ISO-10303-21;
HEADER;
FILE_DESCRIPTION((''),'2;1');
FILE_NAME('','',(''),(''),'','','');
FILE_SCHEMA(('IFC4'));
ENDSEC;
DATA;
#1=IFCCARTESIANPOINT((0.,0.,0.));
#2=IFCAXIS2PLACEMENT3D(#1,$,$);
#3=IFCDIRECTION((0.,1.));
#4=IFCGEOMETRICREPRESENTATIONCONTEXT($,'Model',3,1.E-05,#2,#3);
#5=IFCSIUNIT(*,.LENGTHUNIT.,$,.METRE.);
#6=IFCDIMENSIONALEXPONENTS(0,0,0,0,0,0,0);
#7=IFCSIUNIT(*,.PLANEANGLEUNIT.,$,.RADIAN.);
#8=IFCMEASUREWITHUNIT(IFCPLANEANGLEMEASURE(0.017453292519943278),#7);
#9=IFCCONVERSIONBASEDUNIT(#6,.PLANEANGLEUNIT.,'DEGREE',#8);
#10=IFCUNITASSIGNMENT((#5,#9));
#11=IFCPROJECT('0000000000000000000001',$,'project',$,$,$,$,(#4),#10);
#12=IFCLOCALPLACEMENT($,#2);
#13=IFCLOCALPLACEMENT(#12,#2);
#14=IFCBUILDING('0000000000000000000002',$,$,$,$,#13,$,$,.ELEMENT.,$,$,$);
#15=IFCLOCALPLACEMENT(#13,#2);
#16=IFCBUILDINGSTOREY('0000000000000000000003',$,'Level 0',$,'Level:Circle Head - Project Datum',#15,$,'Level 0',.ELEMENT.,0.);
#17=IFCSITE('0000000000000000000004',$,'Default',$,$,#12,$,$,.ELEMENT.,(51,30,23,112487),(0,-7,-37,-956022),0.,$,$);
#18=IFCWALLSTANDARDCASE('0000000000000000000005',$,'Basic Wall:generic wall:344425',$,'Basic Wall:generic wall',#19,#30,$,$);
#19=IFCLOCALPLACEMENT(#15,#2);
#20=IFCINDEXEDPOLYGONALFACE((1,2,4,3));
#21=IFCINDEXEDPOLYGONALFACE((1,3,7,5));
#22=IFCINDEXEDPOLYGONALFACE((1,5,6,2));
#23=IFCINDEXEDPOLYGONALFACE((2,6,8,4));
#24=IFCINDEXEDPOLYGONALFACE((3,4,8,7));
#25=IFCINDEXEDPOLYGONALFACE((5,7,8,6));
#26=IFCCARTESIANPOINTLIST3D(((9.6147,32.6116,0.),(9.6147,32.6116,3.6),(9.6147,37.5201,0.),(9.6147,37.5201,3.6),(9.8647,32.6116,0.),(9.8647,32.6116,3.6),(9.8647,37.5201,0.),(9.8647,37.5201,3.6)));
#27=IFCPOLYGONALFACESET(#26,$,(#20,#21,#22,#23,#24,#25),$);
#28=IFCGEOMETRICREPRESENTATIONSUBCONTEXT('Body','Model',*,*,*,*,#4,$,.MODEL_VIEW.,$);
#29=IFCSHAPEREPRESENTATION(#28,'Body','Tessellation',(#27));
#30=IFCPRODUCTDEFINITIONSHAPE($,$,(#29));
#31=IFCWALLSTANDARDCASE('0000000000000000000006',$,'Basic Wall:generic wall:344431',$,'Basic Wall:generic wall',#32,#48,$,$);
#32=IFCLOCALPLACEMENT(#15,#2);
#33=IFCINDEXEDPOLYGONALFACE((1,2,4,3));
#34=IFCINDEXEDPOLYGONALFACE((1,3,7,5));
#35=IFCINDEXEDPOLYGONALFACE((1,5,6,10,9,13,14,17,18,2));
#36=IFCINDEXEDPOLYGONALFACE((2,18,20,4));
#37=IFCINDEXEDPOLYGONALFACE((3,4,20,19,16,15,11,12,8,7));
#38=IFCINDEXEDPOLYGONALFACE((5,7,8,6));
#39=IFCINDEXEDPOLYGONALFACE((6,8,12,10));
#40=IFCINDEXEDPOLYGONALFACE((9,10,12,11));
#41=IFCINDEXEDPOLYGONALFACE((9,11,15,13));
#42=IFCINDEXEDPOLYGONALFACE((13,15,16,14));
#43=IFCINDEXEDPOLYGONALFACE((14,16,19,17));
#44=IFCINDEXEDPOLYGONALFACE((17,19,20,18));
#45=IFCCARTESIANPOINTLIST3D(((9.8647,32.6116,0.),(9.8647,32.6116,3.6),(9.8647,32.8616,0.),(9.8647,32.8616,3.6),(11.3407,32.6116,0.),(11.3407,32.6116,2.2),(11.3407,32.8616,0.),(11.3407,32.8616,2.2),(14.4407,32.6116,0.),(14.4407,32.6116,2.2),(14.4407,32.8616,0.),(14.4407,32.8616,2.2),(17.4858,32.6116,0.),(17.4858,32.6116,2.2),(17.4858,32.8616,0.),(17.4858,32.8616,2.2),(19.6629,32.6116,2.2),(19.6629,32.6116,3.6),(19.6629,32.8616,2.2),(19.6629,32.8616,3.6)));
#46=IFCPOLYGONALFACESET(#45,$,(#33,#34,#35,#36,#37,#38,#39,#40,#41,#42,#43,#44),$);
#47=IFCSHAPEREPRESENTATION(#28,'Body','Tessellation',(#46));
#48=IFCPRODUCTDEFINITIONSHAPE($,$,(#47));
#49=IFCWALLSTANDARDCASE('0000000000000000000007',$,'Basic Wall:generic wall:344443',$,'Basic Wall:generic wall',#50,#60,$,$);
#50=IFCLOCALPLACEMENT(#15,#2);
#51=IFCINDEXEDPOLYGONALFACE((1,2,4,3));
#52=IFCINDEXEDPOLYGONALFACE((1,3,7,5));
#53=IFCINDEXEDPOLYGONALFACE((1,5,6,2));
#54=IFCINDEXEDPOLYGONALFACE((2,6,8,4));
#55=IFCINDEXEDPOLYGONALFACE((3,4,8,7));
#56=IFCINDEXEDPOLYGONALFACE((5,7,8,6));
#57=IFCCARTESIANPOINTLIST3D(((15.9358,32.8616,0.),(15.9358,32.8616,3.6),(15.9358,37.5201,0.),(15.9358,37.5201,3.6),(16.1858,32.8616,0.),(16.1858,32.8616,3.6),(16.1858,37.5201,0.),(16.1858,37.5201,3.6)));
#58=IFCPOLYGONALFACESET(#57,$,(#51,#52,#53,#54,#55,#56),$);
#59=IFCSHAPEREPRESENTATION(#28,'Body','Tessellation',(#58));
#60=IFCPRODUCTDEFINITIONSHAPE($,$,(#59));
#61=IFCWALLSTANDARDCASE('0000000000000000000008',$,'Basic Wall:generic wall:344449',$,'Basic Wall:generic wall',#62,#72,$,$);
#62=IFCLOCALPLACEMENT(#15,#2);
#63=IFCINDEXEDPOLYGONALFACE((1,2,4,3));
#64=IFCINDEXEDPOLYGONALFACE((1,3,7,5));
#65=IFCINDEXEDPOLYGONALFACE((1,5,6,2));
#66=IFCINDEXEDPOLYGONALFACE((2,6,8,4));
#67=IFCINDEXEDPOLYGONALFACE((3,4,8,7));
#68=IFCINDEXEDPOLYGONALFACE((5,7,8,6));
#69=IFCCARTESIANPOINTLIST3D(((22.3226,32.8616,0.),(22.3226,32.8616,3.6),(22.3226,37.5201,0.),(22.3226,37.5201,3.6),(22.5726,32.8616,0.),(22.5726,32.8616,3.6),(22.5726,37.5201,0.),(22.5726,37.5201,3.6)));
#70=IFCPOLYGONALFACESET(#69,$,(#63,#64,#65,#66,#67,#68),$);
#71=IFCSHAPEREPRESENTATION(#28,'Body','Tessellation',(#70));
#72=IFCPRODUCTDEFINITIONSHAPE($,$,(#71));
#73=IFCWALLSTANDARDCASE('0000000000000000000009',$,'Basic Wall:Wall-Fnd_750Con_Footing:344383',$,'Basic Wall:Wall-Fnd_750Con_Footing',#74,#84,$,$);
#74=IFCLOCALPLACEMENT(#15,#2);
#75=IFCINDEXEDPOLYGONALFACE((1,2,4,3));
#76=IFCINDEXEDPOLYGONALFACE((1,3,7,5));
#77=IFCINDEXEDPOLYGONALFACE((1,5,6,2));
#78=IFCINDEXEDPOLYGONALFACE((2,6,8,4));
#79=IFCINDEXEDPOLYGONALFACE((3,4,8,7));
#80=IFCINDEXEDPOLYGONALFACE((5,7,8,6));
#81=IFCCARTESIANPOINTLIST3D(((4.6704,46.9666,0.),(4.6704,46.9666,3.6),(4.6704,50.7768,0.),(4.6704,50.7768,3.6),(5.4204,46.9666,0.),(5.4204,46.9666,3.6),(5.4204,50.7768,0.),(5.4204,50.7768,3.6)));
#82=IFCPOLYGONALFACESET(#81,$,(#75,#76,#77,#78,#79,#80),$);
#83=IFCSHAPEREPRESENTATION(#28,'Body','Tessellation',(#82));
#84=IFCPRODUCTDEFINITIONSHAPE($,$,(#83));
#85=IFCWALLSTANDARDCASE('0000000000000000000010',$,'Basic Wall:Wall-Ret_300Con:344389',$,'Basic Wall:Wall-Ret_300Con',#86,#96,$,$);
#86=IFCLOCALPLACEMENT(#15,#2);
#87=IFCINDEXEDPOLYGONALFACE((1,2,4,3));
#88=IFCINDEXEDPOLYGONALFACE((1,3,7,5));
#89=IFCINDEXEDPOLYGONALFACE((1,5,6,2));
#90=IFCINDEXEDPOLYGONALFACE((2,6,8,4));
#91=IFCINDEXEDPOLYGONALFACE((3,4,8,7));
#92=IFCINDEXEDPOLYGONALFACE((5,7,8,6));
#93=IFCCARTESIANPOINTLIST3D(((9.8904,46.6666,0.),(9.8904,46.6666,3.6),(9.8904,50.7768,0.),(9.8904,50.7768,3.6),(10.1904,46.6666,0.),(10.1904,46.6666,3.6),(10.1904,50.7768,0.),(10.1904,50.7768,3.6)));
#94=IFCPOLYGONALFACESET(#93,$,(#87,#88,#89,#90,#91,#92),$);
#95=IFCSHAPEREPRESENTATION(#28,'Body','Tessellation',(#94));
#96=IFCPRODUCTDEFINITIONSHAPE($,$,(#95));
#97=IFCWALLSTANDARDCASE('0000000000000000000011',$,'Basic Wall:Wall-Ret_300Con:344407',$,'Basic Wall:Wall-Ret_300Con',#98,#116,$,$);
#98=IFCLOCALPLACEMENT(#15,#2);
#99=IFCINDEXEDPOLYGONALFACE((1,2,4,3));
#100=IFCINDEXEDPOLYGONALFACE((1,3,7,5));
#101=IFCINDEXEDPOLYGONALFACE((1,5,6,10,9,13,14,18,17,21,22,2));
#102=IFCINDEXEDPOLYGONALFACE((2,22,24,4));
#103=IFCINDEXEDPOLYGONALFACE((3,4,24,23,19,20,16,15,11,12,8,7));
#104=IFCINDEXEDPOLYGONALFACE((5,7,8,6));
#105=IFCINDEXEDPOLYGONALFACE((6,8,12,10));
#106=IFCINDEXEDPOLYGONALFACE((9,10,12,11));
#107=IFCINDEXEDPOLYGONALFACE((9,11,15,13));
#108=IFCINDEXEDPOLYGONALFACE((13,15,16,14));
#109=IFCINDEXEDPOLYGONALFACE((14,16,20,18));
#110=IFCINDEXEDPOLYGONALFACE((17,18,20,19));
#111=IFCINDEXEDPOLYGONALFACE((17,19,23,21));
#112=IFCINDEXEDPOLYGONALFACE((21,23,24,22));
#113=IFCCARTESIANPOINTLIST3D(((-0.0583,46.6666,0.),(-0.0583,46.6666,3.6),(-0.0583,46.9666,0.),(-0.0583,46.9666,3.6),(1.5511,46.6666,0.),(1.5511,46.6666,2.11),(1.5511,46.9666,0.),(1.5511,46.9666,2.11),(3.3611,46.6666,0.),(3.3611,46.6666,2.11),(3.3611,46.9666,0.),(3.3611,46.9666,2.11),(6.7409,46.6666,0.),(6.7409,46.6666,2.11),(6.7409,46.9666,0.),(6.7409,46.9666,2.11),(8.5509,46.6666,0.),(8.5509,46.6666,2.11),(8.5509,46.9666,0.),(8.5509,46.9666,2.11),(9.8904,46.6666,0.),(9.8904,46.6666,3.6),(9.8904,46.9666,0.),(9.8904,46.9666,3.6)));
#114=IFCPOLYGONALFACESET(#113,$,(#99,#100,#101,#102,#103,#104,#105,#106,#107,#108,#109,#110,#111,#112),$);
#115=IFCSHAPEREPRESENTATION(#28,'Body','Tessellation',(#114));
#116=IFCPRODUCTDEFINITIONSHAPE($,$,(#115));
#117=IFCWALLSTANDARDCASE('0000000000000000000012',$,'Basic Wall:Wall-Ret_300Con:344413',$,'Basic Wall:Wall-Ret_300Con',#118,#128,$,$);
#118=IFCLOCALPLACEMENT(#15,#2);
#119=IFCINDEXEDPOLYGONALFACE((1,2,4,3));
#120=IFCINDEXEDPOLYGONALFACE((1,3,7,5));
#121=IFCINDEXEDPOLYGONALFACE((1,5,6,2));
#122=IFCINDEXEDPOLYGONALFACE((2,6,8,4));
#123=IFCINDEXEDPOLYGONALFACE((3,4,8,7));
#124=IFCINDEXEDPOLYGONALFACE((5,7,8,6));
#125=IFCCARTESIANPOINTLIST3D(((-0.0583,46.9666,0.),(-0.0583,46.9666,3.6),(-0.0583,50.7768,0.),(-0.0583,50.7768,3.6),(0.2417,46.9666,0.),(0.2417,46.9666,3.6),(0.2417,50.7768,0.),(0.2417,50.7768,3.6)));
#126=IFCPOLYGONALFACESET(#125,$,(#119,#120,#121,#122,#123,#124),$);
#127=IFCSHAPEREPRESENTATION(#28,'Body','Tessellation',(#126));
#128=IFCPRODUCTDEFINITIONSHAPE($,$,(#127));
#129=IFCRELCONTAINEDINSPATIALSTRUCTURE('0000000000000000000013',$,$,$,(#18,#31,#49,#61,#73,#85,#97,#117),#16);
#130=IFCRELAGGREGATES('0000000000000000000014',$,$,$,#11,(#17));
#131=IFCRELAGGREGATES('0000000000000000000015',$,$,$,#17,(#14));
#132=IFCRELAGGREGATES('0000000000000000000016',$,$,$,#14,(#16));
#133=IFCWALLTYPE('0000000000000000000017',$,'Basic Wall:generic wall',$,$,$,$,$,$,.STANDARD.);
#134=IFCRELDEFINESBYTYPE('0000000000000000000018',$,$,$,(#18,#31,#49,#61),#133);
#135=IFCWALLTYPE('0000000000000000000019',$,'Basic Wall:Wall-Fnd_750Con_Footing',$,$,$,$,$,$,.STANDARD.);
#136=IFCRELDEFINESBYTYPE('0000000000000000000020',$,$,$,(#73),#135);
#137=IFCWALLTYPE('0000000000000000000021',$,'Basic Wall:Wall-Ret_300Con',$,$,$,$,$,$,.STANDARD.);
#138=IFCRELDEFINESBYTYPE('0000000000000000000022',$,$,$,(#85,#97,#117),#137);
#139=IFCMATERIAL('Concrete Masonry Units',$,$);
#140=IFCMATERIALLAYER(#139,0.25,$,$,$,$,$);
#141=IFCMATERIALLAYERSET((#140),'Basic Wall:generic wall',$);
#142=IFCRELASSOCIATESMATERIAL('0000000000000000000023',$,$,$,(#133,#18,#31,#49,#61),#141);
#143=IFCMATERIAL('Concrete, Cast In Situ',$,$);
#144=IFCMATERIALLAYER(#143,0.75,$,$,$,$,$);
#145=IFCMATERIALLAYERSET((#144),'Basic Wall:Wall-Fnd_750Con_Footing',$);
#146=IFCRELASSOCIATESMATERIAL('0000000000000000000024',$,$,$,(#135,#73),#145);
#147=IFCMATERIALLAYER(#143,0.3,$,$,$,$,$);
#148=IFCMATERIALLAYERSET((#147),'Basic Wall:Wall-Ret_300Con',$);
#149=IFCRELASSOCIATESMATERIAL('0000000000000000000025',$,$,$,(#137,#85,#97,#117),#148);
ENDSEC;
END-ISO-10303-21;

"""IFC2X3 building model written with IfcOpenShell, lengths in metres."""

from ifc_helpers import new_model, entity, si_unit, converted_unit, direction, frame, frame_2d, origin, place, context, subcontext, project, spatial, rectangle, extrude, material, layer, layer_set, layer_usage, type_object, element, save


model = new_model("IFC2X3")

# Units and contexts
model_context = context("Model", 3, precision=1e-05, world=origin(), true_north=direction((0.0, 1.0)))
body_context = subcontext(model_context, "Body", "Model", "MODEL_VIEW")
ifc_project = project(units=[si_unit("LENGTHUNIT", "METRE"), converted_unit("PLANEANGLEUNIT", "DEGREE", entity("IfcPlaneAngleMeasure", 0.017453292519943278), si_unit("PLANEANGLEUNIT", "RADIAN"), dimensions=[0, 0, 0, 0, 0, 0, 0])], contexts=[model_context])

# Site, building, storey
site_placement = place(None, origin())
site = spatial("IfcSite", under=ifc_project, at=site_placement, Name="Default", CompositionType="ELEMENT", RefLatitude=(51, 30, 23, 112487), RefLongitude=(0, -7, -37, -956022), RefElevation=0.0)
building_placement = place(site_placement, origin())
building = spatial("IfcBuilding", under=site, at=building_placement, CompositionType="ELEMENT")
storey_placement = place(building_placement, origin())
storey = spatial("IfcBuildingStorey", under=building, at=storey_placement, Name="Level 0", ObjectType="Level:Circle Head - Project Datum", LongName="Level 0", CompositionType="ELEMENT", Elevation=0.0)

# Shared definitions
ifc_material_1 = material(Name="Concrete Masonry Units")
ifc_layer_1 = layer(ifc_material_1, 0.25)
ifc_layer_set_1 = layer_set([ifc_layer_1], Name="Basic Wall:generic wall")
wall_type_1 = type_object("IfcWallType", Name="Basic Wall:generic wall", PredefinedType="STANDARD", material=ifc_layer_set_1)

# Wall
ifc_layer_usage_1 = layer_usage(ifc_layer_set_1, "AXIS2", "NEGATIVE", 0.125)
wall_1_placement = place(storey_placement, frame((9.7397, 32.6116, 0.0), z_axis=(0.0, 0.0, 1.0), x_axis=(0.0, 1.0, 0.0)))
element("IfcWallStandardCase", 1, at=wall_1_placement, inside=storey, type_object=wall_type_1, material=ifc_layer_usage_1, Name="Basic Wall:generic wall:344425", ObjectType="Basic Wall:generic wall", context=body_context, shape_type="SweptSolid", body=[
    extrude(rectangle(XDim=4.9086, YDim=0.25, at=frame_2d((2.4543, 0.0), x_axis=(-1.0, 0.0))), origin(), (0.0, 0.0, 1.0), 3.6),
])

# Wall, openings
ifc_layer_usage_2 = layer_usage(ifc_layer_set_1, "AXIS2", "NEGATIVE", 0.125)
wall_2_placement = place(storey_placement, frame((19.6629, 32.7366, 0.0), z_axis=(0.0, 0.0, 1.0), x_axis=(-1.0, 0.0, 0.0)))
wall_2 = element("IfcWallStandardCase", 2, at=wall_2_placement, inside=storey, type_object=wall_type_1, material=ifc_layer_usage_2, Name="Basic Wall:generic wall:344431", ObjectType="Basic Wall:generic wall", context=body_context, shape_type="SweptSolid", body=[
    extrude(rectangle(XDim=9.7982, YDim=0.25, at=frame_2d((4.8991, 0.0), x_axis=(-1.0, 0.0))), origin(), (0.0, 0.0, 1.0), 3.6),
])
opening_1_placement = place(wall_2_placement, frame((2.1771, 0.125, 0.0)))
element("IfcOpeningElement", 3, at=opening_1_placement, cuts=wall_2, ObjectType="Opening", context=body_context, shape_type="SweptSolid", body=[
    extrude(rectangle(XDim=2.2, YDim=3.1, at=frame_2d((1.1, 1.55), x_axis=(1.0, 0.0))), frame((0.0, 0.0, 0.0), z_axis=(0.0, -1.0, 0.0), x_axis=(0.0, 0.0, 1.0)), (0.0, 0.0, 1.0), 0.25),
])
opening_2_placement = place(wall_2_placement, frame((8.3222, 0.125, 0.0)))
element("IfcOpeningElement", 4, at=opening_2_placement, cuts=wall_2, ObjectType="Opening", context=body_context, shape_type="SweptSolid", body=[
    extrude(rectangle(XDim=2.2, YDim=3.1, at=frame_2d((1.1, 1.55), x_axis=(1.0, 0.0))), frame((0.0, 0.0, 0.0), z_axis=(0.0, -1.0, 0.0), x_axis=(0.0, 0.0, 1.0)), (0.0, 0.0, 1.0), 0.25),
])

# Walls
ifc_layer_usage_3 = layer_usage(ifc_layer_set_1, "AXIS2", "NEGATIVE", 0.125)
wall_3_placement = place(storey_placement, frame((16.0608, 37.5201, 0.0), z_axis=(0.0, 0.0, 1.0), x_axis=(0.0, -1.0, 0.0)))
element("IfcWallStandardCase", 5, at=wall_3_placement, inside=storey, type_object=wall_type_1, material=ifc_layer_usage_3, Name="Basic Wall:generic wall:344443", ObjectType="Basic Wall:generic wall", context=body_context, shape_type="SweptSolid", body=[
    extrude(rectangle(XDim=4.6586, YDim=0.25, at=frame_2d((2.3293, 0.0), x_axis=(-1.0, 0.0))), origin(), (0.0, 0.0, 1.0), 3.6),
])
ifc_layer_usage_4 = layer_usage(ifc_layer_set_1, "AXIS2", "NEGATIVE", 0.125)
wall_4_placement = place(storey_placement, frame((22.4476, 37.5201, 0.0), z_axis=(0.0, 0.0, 1.0), x_axis=(0.0, -1.0, 0.0)))
element("IfcWallStandardCase", 6, at=wall_4_placement, inside=storey, type_object=wall_type_1, material=ifc_layer_usage_4, Name="Basic Wall:generic wall:344449", ObjectType="Basic Wall:generic wall", context=body_context, shape_type="SweptSolid", body=[
    extrude(rectangle(XDim=4.6586, YDim=0.25, at=frame_2d((2.3293, 0.0), x_axis=(-1.0, 0.0))), origin(), (0.0, 0.0, 1.0), 3.6),
])
ifc_material_2 = material(Name="Concrete, Cast In Situ")
ifc_layer_2 = layer(ifc_material_2, 0.75)
ifc_layer_set_2 = layer_set([ifc_layer_2], Name="Basic Wall:Wall-Fnd_750Con_Footing")
ifc_layer_usage_5 = layer_usage(ifc_layer_set_2, "AXIS2", "NEGATIVE", 0.375)
wall_type_2 = type_object("IfcWallType", Name="Basic Wall:Wall-Fnd_750Con_Footing", PredefinedType="STANDARD", material=ifc_layer_set_2)
wall_5_placement = place(storey_placement, frame((5.0454, 50.7768, 0.0), z_axis=(0.0, 0.0, 1.0), x_axis=(0.0, -1.0, 0.0)))
element("IfcWallStandardCase", 7, at=wall_5_placement, inside=storey, type_object=wall_type_2, material=ifc_layer_usage_5, Name="Basic Wall:Wall-Fnd_750Con_Footing:344383", ObjectType="Basic Wall:Wall-Fnd_750Con_Footing", context=body_context, shape_type="SweptSolid", body=[
    extrude(rectangle(XDim=3.8102, YDim=0.75, at=frame_2d((1.9051, 0.0), x_axis=(-1.0, 0.0))), origin(), (0.0, 0.0, 1.0), 3.6),
])
ifc_layer_3 = layer(ifc_material_2, 0.3)
ifc_layer_set_3 = layer_set([ifc_layer_3], Name="Basic Wall:Wall-Ret_300Con")
ifc_layer_usage_6 = layer_usage(ifc_layer_set_3, "AXIS2", "NEGATIVE", 0.15)
wall_type_3 = type_object("IfcWallType", Name="Basic Wall:Wall-Ret_300Con", PredefinedType="STANDARD", material=ifc_layer_set_3)
wall_6_placement = place(storey_placement, frame((10.0404, 46.6666, 0.0), z_axis=(0.0, 0.0, 1.0), x_axis=(0.0, 1.0, 0.0)))
element("IfcWallStandardCase", 8, at=wall_6_placement, inside=storey, type_object=wall_type_3, material=ifc_layer_usage_6, Name="Basic Wall:Wall-Ret_300Con:344389", ObjectType="Basic Wall:Wall-Ret_300Con", context=body_context, shape_type="SweptSolid", body=[
    extrude(rectangle(XDim=4.1102, YDim=0.3, at=frame_2d((2.0551, 0.0), x_axis=(-1.0, 0.0))), origin(), (0.0, 0.0, 1.0), 3.6),
])

# Wall, openings
ifc_layer_usage_7 = layer_usage(ifc_layer_set_3, "AXIS2", "NEGATIVE", 0.15)
wall_7_placement = place(storey_placement, frame((9.8904, 46.8166, 0.0), z_axis=(0.0, 0.0, 1.0), x_axis=(-1.0, 0.0, 0.0)))
wall_7 = element("IfcWallStandardCase", 9, at=wall_7_placement, inside=storey, type_object=wall_type_3, material=ifc_layer_usage_7, Name="Basic Wall:Wall-Ret_300Con:344407", ObjectType="Basic Wall:Wall-Ret_300Con", context=body_context, shape_type="SweptSolid", body=[
    extrude(rectangle(XDim=9.9487, YDim=0.3, at=frame_2d((4.9744, 0.0), x_axis=(1.0, 0.0))), origin(), (0.0, 0.0, 1.0), 3.6),
])
opening_3_placement = place(wall_7_placement, frame((3.1495, 0.15, 0.0)))
element("IfcOpeningElement", 10, at=opening_3_placement, cuts=wall_7, ObjectType="Opening", context=body_context, shape_type="SweptSolid", body=[
    extrude(rectangle(XDim=2.11, YDim=1.81, at=frame_2d((1.055, 0.905), x_axis=(-1.0, 0.0))), frame((0.0, 0.0, 0.0), z_axis=(0.0, -1.0, 0.0), x_axis=(0.0, 0.0, 1.0)), (0.0, 0.0, 1.0), 0.3),
])
opening_4_placement = place(wall_7_placement, frame((8.3394, 0.15, 0.0)))
element("IfcOpeningElement", 11, at=opening_4_placement, cuts=wall_7, ObjectType="Opening", context=body_context, shape_type="SweptSolid", body=[
    extrude(rectangle(XDim=2.11, YDim=1.81, at=frame_2d((1.055, 0.905), x_axis=(-1.0, 0.0))), frame((0.0, 0.0, 0.0), z_axis=(0.0, -1.0, 0.0), x_axis=(0.0, 0.0, 1.0)), (0.0, 0.0, 1.0), 0.3),
])

# Wall
ifc_layer_usage_8 = layer_usage(ifc_layer_set_3, "AXIS2", "NEGATIVE", 0.15)
wall_8_placement = place(storey_placement, frame((0.0917, 46.9666, 0.0), z_axis=(0.0, 0.0, 1.0), x_axis=(0.0, 1.0, 0.0)))
element("IfcWallStandardCase", 12, at=wall_8_placement, inside=storey, type_object=wall_type_3, material=ifc_layer_usage_8, Name="Basic Wall:Wall-Ret_300Con:344413", ObjectType="Basic Wall:Wall-Ret_300Con", context=body_context, shape_type="SweptSolid", body=[
    extrude(rectangle(XDim=3.8102, YDim=0.3, at=frame_2d((1.9051, 0.0), x_axis=(-1.0, 0.0))), origin(), (0.0, 0.0, 1.0), 3.6),
])

save(model, "model.ifc")
